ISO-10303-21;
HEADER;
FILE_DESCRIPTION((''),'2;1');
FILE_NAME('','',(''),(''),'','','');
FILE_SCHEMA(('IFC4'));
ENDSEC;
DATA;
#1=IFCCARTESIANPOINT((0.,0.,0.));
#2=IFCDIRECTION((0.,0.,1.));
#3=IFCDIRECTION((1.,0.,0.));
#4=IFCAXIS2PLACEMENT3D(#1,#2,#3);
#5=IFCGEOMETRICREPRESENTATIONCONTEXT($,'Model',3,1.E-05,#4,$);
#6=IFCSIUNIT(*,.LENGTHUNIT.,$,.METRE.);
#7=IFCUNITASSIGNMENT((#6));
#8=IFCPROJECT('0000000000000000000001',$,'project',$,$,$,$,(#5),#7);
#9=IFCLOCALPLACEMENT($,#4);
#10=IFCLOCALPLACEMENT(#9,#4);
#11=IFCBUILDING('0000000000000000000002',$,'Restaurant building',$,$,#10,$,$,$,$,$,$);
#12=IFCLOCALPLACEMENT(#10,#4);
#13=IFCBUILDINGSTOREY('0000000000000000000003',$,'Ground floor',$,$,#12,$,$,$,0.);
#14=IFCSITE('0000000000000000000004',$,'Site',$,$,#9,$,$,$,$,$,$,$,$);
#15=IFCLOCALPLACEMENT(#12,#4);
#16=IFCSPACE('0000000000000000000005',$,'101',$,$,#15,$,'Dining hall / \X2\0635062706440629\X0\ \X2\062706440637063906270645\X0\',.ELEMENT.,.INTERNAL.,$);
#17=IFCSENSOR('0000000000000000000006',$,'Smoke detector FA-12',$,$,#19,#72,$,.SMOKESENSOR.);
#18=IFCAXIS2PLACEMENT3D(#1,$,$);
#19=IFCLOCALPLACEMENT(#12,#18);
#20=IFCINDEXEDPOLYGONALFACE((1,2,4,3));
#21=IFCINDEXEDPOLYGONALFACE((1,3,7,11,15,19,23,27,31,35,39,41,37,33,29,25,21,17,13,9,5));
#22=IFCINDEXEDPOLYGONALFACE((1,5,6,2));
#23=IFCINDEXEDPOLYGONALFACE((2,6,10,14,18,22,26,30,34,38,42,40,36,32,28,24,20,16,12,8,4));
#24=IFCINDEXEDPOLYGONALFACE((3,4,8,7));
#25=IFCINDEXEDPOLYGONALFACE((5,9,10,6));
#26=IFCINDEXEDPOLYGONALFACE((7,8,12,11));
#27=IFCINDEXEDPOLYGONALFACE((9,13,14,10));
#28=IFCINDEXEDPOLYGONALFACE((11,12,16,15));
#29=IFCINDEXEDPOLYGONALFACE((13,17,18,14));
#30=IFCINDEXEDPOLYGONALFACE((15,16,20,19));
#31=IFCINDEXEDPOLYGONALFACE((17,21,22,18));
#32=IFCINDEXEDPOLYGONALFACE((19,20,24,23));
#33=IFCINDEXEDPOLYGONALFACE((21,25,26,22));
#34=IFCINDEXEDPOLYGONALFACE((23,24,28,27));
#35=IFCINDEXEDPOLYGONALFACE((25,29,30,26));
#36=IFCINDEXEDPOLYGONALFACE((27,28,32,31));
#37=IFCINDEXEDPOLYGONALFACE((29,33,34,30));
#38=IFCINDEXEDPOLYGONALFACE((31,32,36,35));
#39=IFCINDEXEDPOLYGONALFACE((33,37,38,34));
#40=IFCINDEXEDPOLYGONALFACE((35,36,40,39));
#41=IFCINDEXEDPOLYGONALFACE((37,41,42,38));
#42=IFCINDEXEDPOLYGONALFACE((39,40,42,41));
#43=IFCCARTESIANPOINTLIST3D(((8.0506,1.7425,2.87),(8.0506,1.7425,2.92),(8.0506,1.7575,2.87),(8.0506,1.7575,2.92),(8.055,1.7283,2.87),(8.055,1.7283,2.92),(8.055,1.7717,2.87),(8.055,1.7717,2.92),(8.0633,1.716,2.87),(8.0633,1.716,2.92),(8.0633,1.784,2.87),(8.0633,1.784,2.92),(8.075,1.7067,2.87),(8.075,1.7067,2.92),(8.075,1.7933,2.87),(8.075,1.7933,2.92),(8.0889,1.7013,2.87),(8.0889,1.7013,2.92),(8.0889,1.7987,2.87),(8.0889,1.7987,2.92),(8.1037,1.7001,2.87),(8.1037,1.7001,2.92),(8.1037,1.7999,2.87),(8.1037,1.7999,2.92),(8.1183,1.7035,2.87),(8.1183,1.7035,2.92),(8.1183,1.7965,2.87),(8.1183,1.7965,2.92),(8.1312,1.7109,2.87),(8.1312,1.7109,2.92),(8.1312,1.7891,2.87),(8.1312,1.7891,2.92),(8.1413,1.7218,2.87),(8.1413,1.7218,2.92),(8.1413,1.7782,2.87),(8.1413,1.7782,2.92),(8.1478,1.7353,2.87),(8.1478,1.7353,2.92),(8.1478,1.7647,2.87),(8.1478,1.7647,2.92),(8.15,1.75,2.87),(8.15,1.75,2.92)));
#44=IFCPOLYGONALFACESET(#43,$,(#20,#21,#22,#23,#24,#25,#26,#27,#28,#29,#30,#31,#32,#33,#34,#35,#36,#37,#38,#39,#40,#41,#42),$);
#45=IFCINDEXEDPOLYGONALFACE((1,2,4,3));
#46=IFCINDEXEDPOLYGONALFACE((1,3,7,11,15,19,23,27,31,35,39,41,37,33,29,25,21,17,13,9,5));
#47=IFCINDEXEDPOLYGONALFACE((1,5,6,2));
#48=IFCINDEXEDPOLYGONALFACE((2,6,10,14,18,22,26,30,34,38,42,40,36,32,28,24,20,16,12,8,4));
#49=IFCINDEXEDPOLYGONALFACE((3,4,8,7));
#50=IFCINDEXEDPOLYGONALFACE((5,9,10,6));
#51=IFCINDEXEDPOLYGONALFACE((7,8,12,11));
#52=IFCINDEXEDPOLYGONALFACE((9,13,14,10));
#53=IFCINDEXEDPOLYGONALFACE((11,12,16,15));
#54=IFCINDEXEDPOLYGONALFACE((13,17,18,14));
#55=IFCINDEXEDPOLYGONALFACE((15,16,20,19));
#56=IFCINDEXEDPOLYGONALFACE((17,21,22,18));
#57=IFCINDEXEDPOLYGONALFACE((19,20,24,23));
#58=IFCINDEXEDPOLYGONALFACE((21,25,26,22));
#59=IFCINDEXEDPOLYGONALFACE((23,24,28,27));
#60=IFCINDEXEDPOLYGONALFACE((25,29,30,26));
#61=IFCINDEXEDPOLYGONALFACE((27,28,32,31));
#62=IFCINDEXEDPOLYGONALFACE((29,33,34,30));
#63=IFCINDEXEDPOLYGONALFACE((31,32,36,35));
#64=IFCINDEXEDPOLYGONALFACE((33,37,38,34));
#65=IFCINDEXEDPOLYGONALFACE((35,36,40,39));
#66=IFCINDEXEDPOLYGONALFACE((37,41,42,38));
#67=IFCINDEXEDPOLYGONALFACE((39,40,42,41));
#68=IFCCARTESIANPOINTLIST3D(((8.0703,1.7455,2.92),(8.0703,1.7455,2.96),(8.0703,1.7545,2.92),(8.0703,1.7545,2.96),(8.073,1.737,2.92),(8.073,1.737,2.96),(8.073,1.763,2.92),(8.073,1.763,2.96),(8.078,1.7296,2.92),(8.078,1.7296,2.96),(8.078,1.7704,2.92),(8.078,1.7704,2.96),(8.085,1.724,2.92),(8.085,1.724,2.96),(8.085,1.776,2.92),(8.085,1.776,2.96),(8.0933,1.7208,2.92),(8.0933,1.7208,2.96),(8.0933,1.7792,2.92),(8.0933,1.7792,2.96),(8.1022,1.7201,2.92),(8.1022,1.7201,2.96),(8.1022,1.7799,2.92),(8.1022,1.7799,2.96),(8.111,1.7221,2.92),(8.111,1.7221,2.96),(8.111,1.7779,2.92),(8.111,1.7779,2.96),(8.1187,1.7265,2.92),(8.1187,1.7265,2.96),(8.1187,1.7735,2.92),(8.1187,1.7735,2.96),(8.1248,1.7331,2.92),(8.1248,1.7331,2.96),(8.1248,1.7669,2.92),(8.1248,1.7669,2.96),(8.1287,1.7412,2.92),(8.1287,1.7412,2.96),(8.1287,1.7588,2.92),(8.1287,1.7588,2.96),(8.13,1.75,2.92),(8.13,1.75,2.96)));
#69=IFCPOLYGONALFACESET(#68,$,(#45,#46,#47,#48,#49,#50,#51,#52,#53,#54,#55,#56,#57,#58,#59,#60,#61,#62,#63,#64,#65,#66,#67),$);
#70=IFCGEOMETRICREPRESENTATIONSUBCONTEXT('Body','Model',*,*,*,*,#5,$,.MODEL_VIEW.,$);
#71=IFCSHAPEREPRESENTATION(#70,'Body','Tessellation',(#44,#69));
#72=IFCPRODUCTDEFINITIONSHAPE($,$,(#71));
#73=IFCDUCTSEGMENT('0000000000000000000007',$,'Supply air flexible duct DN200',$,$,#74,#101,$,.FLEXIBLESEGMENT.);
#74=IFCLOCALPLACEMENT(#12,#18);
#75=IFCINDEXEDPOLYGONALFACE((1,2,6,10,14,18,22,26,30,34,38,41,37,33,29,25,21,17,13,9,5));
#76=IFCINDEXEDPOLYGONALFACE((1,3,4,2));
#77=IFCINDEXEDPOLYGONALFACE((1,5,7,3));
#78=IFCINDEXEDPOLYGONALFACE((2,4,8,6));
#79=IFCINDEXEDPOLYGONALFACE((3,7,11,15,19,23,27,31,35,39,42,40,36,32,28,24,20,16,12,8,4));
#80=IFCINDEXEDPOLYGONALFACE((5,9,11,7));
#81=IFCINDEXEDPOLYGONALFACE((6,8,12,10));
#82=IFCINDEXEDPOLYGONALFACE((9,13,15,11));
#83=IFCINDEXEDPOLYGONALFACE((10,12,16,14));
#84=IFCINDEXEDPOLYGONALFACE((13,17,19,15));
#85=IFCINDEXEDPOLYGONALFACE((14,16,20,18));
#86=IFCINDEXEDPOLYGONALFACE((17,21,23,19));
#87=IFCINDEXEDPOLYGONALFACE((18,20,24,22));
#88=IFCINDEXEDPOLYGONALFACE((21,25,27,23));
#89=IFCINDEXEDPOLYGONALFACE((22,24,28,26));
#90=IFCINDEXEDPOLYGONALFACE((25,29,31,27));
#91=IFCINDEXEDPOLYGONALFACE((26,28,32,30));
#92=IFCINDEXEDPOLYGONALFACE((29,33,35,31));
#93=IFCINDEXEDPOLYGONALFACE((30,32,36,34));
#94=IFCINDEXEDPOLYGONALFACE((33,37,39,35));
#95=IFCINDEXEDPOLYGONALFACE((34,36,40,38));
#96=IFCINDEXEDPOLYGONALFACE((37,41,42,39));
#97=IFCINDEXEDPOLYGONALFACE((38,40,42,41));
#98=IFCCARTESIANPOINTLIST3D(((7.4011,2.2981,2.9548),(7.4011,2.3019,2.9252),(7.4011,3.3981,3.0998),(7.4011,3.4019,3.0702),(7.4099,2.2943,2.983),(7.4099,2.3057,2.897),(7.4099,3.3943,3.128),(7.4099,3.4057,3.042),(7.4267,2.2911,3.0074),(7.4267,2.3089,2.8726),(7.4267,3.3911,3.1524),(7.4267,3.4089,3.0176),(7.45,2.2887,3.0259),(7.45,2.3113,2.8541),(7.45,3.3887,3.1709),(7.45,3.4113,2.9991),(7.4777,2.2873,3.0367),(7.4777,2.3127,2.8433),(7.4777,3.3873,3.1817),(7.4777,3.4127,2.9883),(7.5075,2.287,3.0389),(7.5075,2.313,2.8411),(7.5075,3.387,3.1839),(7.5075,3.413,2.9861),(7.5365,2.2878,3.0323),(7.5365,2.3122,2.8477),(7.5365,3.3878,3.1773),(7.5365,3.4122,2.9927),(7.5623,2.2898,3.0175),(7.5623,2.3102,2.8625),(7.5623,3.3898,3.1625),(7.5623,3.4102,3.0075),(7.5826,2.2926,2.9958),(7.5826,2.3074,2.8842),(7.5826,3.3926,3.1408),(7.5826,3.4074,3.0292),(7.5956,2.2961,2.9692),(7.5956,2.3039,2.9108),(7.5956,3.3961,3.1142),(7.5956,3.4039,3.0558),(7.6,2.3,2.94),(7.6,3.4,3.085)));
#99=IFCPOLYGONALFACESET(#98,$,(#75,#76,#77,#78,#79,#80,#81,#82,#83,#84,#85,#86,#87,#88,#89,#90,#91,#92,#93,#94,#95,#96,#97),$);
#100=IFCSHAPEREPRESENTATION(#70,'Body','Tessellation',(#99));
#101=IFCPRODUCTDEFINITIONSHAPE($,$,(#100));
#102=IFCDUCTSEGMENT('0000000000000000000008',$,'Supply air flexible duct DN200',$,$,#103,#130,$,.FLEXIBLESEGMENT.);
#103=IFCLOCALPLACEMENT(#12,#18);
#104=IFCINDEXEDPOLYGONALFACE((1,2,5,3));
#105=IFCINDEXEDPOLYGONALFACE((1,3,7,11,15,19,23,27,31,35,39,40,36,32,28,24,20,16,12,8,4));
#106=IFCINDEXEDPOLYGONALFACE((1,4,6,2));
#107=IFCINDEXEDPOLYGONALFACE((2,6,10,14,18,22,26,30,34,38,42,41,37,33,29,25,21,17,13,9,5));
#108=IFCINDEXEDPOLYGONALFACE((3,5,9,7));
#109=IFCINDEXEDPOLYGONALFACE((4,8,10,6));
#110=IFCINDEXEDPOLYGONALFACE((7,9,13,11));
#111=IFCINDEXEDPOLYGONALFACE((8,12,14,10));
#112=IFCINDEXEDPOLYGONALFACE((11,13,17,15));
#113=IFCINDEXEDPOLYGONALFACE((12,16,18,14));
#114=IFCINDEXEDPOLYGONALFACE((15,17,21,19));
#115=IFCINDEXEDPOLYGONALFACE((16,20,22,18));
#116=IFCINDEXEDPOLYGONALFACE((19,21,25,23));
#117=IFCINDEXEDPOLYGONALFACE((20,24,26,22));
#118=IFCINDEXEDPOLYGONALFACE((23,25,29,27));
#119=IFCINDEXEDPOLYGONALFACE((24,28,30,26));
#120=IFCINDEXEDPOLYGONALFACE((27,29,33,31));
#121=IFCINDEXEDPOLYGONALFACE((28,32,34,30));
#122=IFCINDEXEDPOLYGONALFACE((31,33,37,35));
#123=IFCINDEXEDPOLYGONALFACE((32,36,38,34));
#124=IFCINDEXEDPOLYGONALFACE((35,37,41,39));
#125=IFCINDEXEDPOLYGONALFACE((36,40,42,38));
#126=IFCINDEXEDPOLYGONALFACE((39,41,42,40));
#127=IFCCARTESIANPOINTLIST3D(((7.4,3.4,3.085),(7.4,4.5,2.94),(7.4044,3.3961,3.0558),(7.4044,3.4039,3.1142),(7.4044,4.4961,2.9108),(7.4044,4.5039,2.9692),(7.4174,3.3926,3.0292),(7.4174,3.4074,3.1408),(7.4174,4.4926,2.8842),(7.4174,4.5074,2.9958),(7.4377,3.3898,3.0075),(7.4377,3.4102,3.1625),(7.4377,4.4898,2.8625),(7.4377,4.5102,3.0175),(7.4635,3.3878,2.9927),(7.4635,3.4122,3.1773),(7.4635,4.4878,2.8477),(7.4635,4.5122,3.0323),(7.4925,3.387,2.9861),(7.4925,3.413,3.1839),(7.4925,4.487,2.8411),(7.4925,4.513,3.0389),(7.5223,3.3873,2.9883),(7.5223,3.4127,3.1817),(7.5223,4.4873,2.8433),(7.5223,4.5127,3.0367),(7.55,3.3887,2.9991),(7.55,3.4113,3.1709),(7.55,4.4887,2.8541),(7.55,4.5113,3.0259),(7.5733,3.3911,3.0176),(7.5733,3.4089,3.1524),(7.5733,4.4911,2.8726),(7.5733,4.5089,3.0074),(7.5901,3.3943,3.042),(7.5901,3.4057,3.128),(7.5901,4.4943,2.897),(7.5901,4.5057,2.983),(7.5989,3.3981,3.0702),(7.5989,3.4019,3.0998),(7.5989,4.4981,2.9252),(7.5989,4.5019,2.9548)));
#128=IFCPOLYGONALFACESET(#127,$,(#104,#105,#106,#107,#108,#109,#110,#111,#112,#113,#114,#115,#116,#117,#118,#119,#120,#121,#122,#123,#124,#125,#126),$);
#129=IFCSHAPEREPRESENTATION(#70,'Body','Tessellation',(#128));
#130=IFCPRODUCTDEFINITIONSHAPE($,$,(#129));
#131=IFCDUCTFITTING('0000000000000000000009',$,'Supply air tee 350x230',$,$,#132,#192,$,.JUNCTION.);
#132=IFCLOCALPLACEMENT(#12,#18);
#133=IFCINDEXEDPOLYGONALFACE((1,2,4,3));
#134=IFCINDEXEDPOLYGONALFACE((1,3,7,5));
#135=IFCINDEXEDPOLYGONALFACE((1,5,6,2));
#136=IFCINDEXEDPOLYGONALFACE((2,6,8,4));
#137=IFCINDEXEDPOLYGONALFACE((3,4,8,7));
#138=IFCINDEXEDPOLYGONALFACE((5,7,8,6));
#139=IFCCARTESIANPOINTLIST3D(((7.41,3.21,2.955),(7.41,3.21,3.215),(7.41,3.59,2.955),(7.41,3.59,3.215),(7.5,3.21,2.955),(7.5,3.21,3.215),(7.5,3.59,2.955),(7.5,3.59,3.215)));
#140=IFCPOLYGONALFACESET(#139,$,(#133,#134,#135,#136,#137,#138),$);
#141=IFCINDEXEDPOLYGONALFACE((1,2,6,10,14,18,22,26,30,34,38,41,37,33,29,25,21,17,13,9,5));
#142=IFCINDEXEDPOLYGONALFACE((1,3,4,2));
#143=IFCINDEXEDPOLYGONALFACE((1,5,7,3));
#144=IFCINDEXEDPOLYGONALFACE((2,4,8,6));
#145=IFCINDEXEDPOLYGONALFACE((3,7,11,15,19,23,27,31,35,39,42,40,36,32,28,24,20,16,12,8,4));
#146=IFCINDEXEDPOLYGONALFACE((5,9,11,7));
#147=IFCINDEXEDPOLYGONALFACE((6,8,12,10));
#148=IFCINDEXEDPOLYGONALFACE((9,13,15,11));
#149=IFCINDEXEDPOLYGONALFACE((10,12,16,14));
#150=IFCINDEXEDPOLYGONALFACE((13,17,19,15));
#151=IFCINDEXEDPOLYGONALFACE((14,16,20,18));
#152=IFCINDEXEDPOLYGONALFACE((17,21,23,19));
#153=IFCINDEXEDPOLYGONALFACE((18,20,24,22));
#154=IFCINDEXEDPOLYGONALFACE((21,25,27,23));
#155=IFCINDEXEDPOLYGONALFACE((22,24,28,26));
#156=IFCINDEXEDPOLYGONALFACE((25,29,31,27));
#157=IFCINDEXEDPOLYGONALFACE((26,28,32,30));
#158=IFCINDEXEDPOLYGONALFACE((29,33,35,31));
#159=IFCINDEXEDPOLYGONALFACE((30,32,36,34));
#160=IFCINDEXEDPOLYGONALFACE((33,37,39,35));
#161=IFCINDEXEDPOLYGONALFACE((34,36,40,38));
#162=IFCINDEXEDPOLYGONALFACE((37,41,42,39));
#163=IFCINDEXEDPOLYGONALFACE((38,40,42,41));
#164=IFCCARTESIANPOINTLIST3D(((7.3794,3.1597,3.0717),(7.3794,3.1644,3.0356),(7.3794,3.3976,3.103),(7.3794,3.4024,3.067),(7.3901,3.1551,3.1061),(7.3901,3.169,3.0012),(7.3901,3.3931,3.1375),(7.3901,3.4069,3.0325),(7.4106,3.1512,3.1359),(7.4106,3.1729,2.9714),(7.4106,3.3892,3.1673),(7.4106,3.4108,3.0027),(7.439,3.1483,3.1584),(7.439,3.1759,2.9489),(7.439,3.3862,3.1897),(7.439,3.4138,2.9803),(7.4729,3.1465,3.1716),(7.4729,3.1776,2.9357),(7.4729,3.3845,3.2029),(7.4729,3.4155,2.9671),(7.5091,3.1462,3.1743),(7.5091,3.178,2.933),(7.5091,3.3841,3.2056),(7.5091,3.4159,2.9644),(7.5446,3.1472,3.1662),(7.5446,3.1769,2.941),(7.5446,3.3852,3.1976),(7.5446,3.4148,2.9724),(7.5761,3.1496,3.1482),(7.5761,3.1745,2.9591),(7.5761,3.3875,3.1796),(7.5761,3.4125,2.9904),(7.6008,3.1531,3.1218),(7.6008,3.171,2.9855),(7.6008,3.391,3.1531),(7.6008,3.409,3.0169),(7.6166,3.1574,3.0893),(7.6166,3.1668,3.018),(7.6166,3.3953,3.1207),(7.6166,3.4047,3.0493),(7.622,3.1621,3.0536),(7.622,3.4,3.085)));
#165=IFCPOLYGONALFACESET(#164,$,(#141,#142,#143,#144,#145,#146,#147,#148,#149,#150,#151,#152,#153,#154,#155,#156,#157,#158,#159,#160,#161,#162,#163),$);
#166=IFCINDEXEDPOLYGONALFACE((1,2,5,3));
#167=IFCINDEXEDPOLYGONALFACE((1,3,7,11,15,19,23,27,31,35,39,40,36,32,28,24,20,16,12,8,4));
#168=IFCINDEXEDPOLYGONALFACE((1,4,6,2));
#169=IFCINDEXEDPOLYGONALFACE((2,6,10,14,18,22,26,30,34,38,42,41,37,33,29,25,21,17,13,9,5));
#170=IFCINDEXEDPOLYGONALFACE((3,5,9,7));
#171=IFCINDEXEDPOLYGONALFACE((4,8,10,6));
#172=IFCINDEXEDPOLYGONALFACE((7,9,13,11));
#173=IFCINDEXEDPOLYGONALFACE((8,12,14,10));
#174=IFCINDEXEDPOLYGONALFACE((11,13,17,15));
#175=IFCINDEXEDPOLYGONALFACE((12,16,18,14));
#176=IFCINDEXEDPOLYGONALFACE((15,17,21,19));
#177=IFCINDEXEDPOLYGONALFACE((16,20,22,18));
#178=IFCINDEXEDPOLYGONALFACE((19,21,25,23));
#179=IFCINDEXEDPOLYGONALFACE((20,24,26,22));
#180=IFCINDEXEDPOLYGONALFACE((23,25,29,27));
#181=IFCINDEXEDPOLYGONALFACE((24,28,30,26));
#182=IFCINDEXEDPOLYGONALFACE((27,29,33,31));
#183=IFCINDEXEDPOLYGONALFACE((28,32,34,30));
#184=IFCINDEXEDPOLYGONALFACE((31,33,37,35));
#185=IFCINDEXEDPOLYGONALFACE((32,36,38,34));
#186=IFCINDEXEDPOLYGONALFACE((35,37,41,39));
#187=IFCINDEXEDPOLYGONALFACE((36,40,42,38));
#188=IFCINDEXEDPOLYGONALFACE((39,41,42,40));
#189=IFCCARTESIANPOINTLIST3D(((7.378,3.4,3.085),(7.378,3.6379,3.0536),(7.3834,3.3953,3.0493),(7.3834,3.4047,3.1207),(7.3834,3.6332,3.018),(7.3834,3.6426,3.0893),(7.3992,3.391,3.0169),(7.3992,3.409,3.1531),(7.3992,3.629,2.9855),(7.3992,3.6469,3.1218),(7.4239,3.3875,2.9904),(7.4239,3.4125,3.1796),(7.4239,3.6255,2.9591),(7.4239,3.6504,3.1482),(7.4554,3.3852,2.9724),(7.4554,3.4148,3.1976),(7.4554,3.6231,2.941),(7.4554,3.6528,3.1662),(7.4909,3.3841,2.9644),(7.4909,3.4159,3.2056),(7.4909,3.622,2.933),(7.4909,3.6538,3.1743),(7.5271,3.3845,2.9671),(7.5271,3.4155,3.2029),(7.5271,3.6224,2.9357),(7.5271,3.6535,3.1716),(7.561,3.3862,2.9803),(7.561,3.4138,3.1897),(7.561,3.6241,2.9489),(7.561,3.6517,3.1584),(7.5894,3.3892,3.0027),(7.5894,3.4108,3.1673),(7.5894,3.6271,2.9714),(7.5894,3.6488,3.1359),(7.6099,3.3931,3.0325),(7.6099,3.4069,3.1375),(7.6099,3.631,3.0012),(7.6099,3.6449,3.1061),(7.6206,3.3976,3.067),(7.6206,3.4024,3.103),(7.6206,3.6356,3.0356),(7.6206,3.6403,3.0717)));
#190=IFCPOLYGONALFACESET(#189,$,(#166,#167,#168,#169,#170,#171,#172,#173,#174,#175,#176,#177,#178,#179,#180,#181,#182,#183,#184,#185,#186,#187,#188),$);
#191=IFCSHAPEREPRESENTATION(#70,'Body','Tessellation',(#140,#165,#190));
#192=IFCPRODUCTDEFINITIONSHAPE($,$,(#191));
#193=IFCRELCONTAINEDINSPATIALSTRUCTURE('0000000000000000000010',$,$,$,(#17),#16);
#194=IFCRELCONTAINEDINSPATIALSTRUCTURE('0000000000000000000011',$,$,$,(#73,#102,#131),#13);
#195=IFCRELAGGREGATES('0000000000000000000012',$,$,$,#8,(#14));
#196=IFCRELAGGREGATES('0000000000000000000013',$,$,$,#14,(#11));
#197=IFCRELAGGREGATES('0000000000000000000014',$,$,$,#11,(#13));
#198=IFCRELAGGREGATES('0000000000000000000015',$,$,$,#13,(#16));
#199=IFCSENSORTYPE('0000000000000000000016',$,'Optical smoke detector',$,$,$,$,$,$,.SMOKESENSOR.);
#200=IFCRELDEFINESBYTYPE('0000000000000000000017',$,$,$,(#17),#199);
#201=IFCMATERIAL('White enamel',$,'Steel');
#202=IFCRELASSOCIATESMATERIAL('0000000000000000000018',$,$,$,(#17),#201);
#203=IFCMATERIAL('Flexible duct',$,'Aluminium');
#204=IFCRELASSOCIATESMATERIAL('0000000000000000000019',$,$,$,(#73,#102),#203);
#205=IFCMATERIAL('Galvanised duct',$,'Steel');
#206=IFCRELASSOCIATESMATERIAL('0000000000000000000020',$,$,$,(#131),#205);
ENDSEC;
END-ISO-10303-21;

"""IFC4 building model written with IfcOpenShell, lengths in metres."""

from ifc_helpers import new_model, si_unit, frame, origin, origin_with_axes, origin_2d, place, context, subcontext, project, spatial, rectangle, circle, extrude, source, transform, mapped, material, type_object, type_shapes, element, save


model = new_model("IFC4")

# Units and contexts
model_context = context("Model", 3, precision=1e-05, world=origin_with_axes())
body_context = subcontext(model_context, "Body", "Model", "MODEL_VIEW")
ifc_project = project(units=[si_unit("LENGTHUNIT", "METRE")], contexts=[model_context])

# Site, building, storey
site_placement = place(None, origin_with_axes())
site = spatial("IfcSite", under=ifc_project, at=site_placement, Name="Site")
building_placement = place(site_placement, origin_with_axes())
building = spatial("IfcBuilding", under=site, at=building_placement, Name="Restaurant building")
storey_placement = place(building_placement, origin_with_axes())
storey = spatial("IfcBuildingStorey", under=building, at=storey_placement, Name="Ground floor", Elevation=0.0)

# Shared definitions
ifc_material_1 = material(Name="White enamel", Category="Steel")

# Shared definitions
space_placement = place(storey_placement, origin_with_axes())
space = spatial("IfcSpace", under=storey, at=space_placement, Name="101", LongName="Dining hall / صالة الطعام", CompositionType="ELEMENT", PredefinedType="INTERNAL")

# Sensor
sensor_type = type_object("IfcSensorType", Name="Optical smoke detector", PredefinedType="SMOKESENSOR")
shared_shape_1 = source(origin(), body_context, "Body", "SweptSolid", [
    extrude(circle(Radius=0.05, at=origin_2d()), frame((0.0, 0.0, -0.09)), (0.0, 0.0, 1.0), 0.05),
    extrude(circle(Radius=0.03, at=origin_2d()), frame((0.0, 0.0, -0.04)), (0.0, 0.0, 1.0), 0.04),
])
type_shapes(sensor_type, [shared_shape_1])
sensor_placement = place(storey_placement, frame((8.1, 1.75, 2.96)))
element("IfcSensor", 1, at=sensor_placement, inside=space, type_object=sensor_type, material=ifc_material_1, Name="Smoke detector FA-12", PredefinedType="SMOKESENSOR", context=body_context, shape_type="MappedRepresentation", body=[
    mapped(shared_shape_1, transform((0.0, 0.0, 0.0))),
])

# Duct segments
ifc_material_2 = material(Name="Flexible duct", Category="Aluminium")
duct_segment_1_placement = place(storey_placement, frame((7.5, 3.4, 3.085)))
element("IfcDuctSegment", 2, at=duct_segment_1_placement, inside=storey, material=ifc_material_2, Name="Supply air flexible duct DN200", PredefinedType="FLEXIBLESEGMENT", context=body_context, shape_type="SweptSolid", body=[
    extrude(circle(Radius=0.1, at=origin_2d()), frame((0.0, 0.0, 0.0), z_axis=(0.0, -0.991424, -0.130688), x_axis=(1.0, 0.0, 0.0)), (0.0, 0.0, 1.0), 1.1095),
])
duct_segment_2_placement = place(storey_placement, frame((7.5, 3.4, 3.085)))
element("IfcDuctSegment", 3, at=duct_segment_2_placement, inside=storey, material=ifc_material_2, Name="Supply air flexible duct DN200", PredefinedType="FLEXIBLESEGMENT", context=body_context, shape_type="SweptSolid", body=[
    extrude(circle(Radius=0.1, at=origin_2d()), frame((0.0, 0.0, 0.0), z_axis=(0.0, 0.991424, -0.130688), x_axis=(-1.0, 0.0, 0.0)), (0.0, 0.0, 1.0), 1.1095),
])

# Duct fitting
ifc_material_3 = material(Name="Galvanised duct", Category="Steel")
duct_fitting_placement = place(storey_placement, frame((7.5, 3.4, 3.085)))
element("IfcDuctFitting", 4, at=duct_fitting_placement, inside=storey, material=ifc_material_3, Name="Supply air tee 350x230", PredefinedType="JUNCTION", context=body_context, shape_type="SweptSolid", body=[
    extrude(rectangle(XDim=0.38, YDim=0.26, at=origin_2d()), frame((0.0, 0.0, 0.0), z_axis=(-1.0, 0.0, 0.0), x_axis=(0.0, -1.0, 0.0)), (0.0, 0.0, 1.0), 0.09),
    extrude(circle(Radius=0.122, at=origin_2d()), frame((0.0, 0.0, 0.0), z_axis=(0.0, -0.991424, -0.130688), x_axis=(1.0, 0.0, 0.0)), (0.0, 0.0, 1.0), 0.24),
    extrude(circle(Radius=0.122, at=origin_2d()), frame((0.0, 0.0, 0.0), z_axis=(0.0, 0.991424, -0.130688), x_axis=(-1.0, 0.0, 0.0)), (0.0, 0.0, 1.0), 0.24),
])

save(model, "model.ifc")
